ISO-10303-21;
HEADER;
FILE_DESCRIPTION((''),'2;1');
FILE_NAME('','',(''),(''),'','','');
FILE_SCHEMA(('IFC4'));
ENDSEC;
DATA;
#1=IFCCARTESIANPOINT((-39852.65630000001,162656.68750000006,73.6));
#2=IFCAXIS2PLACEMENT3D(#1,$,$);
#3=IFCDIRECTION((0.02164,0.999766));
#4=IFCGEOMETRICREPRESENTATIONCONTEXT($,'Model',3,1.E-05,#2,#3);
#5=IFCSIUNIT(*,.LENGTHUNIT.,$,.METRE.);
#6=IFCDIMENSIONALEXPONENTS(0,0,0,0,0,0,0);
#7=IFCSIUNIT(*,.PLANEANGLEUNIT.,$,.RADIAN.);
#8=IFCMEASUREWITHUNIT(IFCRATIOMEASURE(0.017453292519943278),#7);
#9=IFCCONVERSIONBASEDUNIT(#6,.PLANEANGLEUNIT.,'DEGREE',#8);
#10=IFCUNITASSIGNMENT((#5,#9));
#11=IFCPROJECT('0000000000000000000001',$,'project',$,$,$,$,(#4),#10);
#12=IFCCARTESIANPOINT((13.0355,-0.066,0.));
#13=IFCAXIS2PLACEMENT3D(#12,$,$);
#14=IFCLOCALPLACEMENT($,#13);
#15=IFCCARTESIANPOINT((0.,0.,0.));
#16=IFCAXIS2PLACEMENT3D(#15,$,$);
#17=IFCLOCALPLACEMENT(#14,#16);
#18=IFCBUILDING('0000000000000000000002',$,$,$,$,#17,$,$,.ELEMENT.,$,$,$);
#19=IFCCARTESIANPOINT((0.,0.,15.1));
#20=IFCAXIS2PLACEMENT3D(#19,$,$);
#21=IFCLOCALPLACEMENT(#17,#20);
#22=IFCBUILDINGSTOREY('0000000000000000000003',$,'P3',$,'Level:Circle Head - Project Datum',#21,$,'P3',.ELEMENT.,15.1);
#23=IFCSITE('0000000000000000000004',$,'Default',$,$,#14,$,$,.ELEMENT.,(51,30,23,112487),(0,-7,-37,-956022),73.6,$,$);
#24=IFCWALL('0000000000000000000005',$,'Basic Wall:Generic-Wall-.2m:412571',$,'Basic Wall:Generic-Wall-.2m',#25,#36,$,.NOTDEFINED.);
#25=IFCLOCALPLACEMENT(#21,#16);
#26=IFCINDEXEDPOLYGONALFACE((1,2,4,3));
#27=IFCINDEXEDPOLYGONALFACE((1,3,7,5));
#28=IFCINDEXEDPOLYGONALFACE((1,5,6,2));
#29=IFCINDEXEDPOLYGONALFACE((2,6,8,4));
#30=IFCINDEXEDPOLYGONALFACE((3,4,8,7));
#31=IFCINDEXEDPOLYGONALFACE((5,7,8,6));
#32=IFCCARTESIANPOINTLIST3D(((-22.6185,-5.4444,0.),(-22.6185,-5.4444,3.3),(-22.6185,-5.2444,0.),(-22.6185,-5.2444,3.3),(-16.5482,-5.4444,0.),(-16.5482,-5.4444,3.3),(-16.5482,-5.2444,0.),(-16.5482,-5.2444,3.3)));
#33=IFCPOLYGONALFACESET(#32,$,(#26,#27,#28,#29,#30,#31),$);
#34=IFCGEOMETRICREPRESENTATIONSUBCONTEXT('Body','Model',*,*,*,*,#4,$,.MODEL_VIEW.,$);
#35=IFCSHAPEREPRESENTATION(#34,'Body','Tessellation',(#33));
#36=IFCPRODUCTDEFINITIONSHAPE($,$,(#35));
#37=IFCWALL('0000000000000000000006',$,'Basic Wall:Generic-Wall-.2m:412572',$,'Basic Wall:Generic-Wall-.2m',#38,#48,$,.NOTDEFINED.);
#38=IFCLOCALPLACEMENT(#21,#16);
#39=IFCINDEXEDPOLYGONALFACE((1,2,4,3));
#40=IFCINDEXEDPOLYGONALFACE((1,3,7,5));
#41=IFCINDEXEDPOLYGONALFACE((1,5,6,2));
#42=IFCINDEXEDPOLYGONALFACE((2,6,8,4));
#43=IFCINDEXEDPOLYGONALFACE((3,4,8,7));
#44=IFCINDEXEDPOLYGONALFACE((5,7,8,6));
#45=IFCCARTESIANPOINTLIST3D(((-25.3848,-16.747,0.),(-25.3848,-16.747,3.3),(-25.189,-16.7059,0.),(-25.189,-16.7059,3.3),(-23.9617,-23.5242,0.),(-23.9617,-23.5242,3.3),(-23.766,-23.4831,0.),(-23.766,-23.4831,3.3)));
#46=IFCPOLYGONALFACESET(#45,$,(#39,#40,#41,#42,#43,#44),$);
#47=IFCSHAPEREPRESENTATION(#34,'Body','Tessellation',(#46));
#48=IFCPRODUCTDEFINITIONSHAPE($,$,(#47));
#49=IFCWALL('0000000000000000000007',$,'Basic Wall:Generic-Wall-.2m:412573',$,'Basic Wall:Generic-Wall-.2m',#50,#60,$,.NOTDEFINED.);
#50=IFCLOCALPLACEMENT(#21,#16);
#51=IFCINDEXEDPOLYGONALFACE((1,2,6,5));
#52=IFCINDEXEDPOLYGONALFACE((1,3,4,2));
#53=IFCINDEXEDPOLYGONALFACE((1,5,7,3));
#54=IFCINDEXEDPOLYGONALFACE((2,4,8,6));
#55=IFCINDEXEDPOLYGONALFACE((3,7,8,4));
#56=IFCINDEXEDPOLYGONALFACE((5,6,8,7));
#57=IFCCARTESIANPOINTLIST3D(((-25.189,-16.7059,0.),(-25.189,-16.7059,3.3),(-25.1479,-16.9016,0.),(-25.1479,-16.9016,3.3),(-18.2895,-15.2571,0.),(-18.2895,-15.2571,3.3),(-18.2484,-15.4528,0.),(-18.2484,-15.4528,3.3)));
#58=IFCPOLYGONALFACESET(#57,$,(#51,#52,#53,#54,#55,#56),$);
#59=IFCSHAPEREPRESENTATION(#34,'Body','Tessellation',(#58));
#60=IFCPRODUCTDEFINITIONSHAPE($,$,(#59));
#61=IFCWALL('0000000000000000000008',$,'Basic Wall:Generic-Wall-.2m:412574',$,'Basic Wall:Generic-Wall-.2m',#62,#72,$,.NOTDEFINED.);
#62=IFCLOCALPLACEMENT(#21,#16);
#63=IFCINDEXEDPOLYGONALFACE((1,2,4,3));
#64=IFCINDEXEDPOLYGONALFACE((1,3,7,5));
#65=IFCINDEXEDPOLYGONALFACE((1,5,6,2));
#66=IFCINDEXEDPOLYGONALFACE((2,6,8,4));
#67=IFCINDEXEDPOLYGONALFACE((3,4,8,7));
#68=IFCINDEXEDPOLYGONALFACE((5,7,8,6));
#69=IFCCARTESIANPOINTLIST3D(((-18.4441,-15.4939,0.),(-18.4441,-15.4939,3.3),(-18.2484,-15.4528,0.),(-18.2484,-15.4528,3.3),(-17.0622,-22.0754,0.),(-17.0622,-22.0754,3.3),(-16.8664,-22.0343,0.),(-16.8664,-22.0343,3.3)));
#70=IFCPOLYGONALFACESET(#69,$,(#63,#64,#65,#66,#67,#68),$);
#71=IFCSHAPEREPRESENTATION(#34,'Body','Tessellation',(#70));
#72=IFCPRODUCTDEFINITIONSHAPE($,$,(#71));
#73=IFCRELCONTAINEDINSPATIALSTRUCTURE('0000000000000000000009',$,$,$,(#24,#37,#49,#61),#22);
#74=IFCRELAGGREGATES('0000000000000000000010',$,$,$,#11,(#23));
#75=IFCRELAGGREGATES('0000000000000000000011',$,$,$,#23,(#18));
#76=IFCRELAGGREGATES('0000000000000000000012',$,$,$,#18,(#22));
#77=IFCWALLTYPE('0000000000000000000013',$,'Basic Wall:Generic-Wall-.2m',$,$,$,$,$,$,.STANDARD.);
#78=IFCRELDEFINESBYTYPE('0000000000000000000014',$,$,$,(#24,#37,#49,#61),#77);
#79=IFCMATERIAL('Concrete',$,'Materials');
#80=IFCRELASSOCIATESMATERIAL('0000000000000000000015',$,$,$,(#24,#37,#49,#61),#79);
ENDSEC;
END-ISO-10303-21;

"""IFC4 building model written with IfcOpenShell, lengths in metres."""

from ifc_helpers import new_model, entity, si_unit, converted_unit, direction, frame, origin, place, context, subcontext, project, spatial, indexed_curve, outline, extrude, material, type_object, element, save


model = new_model("IFC4")

# Units and contexts
model_context = context("Model", 3, precision=1e-05, world=frame((-39852.65630000001, 162656.68750000006, 73.6)), true_north=direction((0.02164, 0.999766)))
body_context = subcontext(model_context, "Body", "Model", "MODEL_VIEW")
ifc_project = project(units=[si_unit("LENGTHUNIT", "METRE"), converted_unit("PLANEANGLEUNIT", "DEGREE", entity("IfcRatioMeasure", 0.017453292519943278), si_unit("PLANEANGLEUNIT", "RADIAN"), dimensions=[0, 0, 0, 0, 0, 0, 0])], contexts=[model_context])

# Site, building, storey
site_placement = place(None, frame((13.0355, -0.066, 0.0)))
site = spatial("IfcSite", under=ifc_project, at=site_placement, Name="Default", CompositionType="ELEMENT", RefLatitude=(51, 30, 23, 112487), RefLongitude=(0, -7, -37, -956022), RefElevation=73.6)
building_placement = place(site_placement, origin())
building = spatial("IfcBuilding", under=site, at=building_placement, CompositionType="ELEMENT")
storey_placement = place(building_placement, frame((0.0, 0.0, 15.1)))
storey = spatial("IfcBuildingStorey", under=building, at=storey_placement, Name="P3", ObjectType="Level:Circle Head - Project Datum", LongName="P3", CompositionType="ELEMENT", Elevation=15.1)

# Shared definitions
ifc_material = material(Name="Concrete", Category="Materials")

# Walls
wall_type_1 = type_object("IfcWallType", Name="Basic Wall:Generic-Wall-.2m", PredefinedType="STANDARD")
wall_1_placement = place(storey_placement, frame((-22.6185, -5.3444, 0.0)))
element("IfcWall", 1, at=wall_1_placement, inside=storey, type_object=wall_type_1, material=ifc_material, Name="Basic Wall:Generic-Wall-.2m:412571", ObjectType="Basic Wall:Generic-Wall-.2m", PredefinedType="NOTDEFINED", context=body_context, shape_type="SweptSolid", body=[
    extrude(outline(indexed_curve([(6.0702, 0.1), (0.0, 0.1), (0.0, -0.1), (6.0702, -0.1), (6.0702, 0.1)], self_intersect=False)), origin(), (0.0, 0.0, 1.0), 3.3),
])
wall_2_placement = place(storey_placement, frame((-23.8638, -23.5036, 0.0), z_axis=(0.0, 0.0, 1.0), x_axis=(-0.2055, 0.978657, 0.0)))
element("IfcWall", 2, at=wall_2_placement, inside=storey, type_object=wall_type_1, material=ifc_material, Name="Basic Wall:Generic-Wall-.2m:412572", ObjectType="Basic Wall:Generic-Wall-.2m", PredefinedType="NOTDEFINED", context=body_context, shape_type="SweptSolid", body=[
    extrude(outline(indexed_curve([(6.925, 0.1), (0.0, 0.1), (0.0, -0.1), (6.925, -0.1), (6.925, 0.1)], self_intersect=False)), origin(), (0.0, 0.0, 1.0), 3.3),
])
wall_3_placement = place(storey_placement, frame((-25.1685, -16.8038, 0.0), z_axis=(0.0, 0.0, 1.0), x_axis=(0.978657, 0.2055, 0.0)))
element("IfcWall", 3, at=wall_3_placement, inside=storey, type_object=wall_type_1, material=ifc_material, Name="Basic Wall:Generic-Wall-.2m:412573", ObjectType="Basic Wall:Generic-Wall-.2m", PredefinedType="NOTDEFINED", context=body_context, shape_type="SweptSolid", body=[
    extrude(outline(indexed_curve([(7.05, 0.1), (0.0, 0.1), (0.0, -0.1), (7.05, -0.1), (7.05, 0.1)], self_intersect=False)), origin(), (0.0, 0.0, 1.0), 3.3),
])
wall_4_placement = place(storey_placement, frame((-18.3463, -15.4734, 0.0), z_axis=(0.0, 0.0, 1.0), x_axis=(0.2055, -0.978657, 0.0)))
element("IfcWall", 4, at=wall_4_placement, inside=storey, type_object=wall_type_1, material=ifc_material, Name="Basic Wall:Generic-Wall-.2m:412574", ObjectType="Basic Wall:Generic-Wall-.2m", PredefinedType="NOTDEFINED", context=body_context, shape_type="SweptSolid", body=[
    extrude(outline(indexed_curve([(6.725, 0.1), (0.0, 0.1), (0.0, -0.1), (6.725, -0.1), (6.725, 0.1)], self_intersect=False)), origin(), (0.0, 0.0, 1.0), 3.3),
])

save(model, "model.ifc")
